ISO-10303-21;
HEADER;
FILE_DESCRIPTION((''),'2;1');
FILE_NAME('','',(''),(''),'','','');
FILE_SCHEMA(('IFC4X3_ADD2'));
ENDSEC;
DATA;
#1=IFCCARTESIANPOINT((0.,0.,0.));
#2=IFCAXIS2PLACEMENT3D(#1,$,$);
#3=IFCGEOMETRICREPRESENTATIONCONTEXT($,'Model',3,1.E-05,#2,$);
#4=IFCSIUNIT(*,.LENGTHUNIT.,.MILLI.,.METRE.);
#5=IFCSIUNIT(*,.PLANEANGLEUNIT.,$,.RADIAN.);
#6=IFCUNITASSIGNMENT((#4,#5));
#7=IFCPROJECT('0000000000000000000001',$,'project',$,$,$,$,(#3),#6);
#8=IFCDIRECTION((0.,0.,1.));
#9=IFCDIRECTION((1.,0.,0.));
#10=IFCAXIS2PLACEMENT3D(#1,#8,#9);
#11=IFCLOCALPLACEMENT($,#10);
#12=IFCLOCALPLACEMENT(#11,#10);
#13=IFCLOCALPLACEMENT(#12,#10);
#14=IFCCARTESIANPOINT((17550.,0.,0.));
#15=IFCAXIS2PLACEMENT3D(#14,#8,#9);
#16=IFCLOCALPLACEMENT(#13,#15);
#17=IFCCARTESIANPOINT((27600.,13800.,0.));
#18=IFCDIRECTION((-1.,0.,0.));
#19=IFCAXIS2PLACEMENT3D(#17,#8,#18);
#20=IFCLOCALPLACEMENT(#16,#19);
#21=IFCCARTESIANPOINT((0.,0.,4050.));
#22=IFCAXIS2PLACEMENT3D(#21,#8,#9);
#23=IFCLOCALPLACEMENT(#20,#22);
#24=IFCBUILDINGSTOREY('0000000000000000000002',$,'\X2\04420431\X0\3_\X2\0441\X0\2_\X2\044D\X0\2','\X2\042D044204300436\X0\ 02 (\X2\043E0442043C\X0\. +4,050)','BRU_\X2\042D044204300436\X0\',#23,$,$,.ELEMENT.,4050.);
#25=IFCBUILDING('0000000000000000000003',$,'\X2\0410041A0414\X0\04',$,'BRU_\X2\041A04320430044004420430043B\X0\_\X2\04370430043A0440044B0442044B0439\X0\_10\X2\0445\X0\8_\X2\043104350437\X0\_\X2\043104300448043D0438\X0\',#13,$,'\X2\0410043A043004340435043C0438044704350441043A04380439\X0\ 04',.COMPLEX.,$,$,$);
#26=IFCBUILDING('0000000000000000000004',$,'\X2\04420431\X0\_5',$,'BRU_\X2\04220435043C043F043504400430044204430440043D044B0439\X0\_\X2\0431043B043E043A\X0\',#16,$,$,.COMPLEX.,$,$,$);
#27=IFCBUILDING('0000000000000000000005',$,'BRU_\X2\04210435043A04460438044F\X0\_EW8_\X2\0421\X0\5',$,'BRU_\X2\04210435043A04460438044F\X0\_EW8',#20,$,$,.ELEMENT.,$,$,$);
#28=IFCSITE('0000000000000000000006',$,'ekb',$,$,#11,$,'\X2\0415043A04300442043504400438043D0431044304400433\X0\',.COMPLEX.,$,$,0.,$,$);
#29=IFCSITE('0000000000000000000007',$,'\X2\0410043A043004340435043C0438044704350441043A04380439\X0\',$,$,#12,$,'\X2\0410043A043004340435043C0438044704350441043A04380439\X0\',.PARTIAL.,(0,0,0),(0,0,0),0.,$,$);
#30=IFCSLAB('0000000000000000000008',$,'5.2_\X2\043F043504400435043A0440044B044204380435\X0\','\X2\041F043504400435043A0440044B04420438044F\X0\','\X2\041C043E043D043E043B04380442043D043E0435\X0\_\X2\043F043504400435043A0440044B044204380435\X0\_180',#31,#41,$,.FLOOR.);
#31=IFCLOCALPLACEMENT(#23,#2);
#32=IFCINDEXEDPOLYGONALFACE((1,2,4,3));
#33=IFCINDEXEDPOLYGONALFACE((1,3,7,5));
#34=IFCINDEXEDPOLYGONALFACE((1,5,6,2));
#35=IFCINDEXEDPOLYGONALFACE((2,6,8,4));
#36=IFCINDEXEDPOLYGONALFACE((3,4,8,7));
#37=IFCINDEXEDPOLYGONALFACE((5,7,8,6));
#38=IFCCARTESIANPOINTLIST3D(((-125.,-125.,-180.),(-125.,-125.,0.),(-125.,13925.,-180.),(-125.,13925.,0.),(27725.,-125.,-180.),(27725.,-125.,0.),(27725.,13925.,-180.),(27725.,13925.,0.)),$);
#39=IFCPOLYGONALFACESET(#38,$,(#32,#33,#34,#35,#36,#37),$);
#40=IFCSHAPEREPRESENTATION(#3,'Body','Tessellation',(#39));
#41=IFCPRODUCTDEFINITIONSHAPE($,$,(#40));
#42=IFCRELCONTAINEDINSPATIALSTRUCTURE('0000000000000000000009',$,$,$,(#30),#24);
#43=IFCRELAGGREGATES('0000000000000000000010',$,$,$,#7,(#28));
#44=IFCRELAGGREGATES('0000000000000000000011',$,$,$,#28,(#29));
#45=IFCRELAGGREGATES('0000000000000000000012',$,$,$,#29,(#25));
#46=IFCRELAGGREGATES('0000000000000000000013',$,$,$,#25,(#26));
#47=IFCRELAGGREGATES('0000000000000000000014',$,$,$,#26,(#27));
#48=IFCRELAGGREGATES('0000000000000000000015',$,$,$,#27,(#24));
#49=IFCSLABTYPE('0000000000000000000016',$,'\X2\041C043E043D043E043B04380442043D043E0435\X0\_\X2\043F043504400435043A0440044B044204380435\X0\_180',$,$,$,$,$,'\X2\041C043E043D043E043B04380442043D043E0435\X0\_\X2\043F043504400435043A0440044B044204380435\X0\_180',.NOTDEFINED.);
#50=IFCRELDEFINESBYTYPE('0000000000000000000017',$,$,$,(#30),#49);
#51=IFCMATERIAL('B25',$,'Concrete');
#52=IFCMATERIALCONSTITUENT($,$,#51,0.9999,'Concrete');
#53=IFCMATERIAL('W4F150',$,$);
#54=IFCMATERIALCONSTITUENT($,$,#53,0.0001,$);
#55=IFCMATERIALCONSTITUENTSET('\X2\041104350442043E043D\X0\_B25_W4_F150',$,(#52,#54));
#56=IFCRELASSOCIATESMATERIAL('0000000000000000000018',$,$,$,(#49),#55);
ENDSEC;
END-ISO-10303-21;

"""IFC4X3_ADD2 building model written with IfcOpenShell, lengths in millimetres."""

from ifc_helpers import new_model, si_unit, frame, origin, origin_with_axes, place, context, project, spatial, polyline, outline, extrude, material, constituent, constituent_set, type_object, element, save


model = new_model("IFC4X3_ADD2")

# Units and contexts
model_context = context("Model", 3, precision=1e-05, world=origin())
ifc_project = project(units=[si_unit("LENGTHUNIT", "METRE", prefix="MILLI"), si_unit("PLANEANGLEUNIT", "RADIAN")], contexts=[model_context])

# Sites, buildings, storey
site_1_placement = place(None, origin_with_axes())
site_1 = spatial("IfcSite", under=ifc_project, at=site_1_placement, Name="ekb", LongName="Екатеринбург", CompositionType="COMPLEX", RefElevation=0.0)
site_2_placement = place(site_1_placement, origin_with_axes())
site_2 = spatial("IfcSite", under=site_1, at=site_2_placement, Name="Академический", LongName="Академический", CompositionType="PARTIAL", RefLatitude=(0, 0, 0), RefLongitude=(0, 0, 0), RefElevation=0.0)
building_1_placement = place(site_2_placement, origin_with_axes())
building_1 = spatial("IfcBuilding", under=site_2, at=building_1_placement, Name="АКД04", ObjectType="BRU_Квартал_закрытый_10х8_без_башни", LongName="Академический 04", CompositionType="COMPLEX")
building_2_placement = place(building_1_placement, frame((17550.0, 0.0, 0.0), z_axis=(0.0, 0.0, 1.0), x_axis=(1.0, 0.0, 0.0)))
building_2 = spatial("IfcBuilding", under=building_1, at=building_2_placement, Name="тб_5", ObjectType="BRU_Температурный_блок", CompositionType="COMPLEX")
building_3_placement = place(building_2_placement, frame((27600.0, 13800.0, 0.0), z_axis=(0.0, 0.0, 1.0), x_axis=(-1.0, 0.0, 0.0)))
building_3 = spatial("IfcBuilding", under=building_2, at=building_3_placement, Name="BRU_Секция_EW8_С5", ObjectType="BRU_Секция_EW8", CompositionType="ELEMENT")
storey_placement = place(building_3_placement, frame((0.0, 0.0, 4050.0), z_axis=(0.0, 0.0, 1.0), x_axis=(1.0, 0.0, 0.0)))
storey = spatial("IfcBuildingStorey", under=building_3, at=storey_placement, Name="тб3_с2_э2", Description="Этаж 02 (отм. +4,050)", ObjectType="BRU_Этаж", CompositionType="ELEMENT", Elevation=4050.0)

# Shared definitions
ifc_material_1 = material(Name="B25", Category="Concrete")
ifc_material_2 = material(Name="W4F150")

# Slab
ifc_constituent_1 = constituent(ifc_material_1, Category="Concrete", fraction=0.9999)
ifc_constituent_2 = constituent(ifc_material_2, fraction=0.0001)
ifc_constituent_set_1 = constituent_set(constituents=[ifc_constituent_1, ifc_constituent_2], Name="Бетон_B25_W4_F150")
slab_type = type_object("IfcSlabType", Name="Монолитное_перекрытие_180", ElementType="Монолитное_перекрытие_180", PredefinedType="NOTDEFINED", material=ifc_constituent_set_1)
slab_placement = place(storey_placement, frame((0.0, 0.0, -180.0), z_axis=(0.0, 0.0, 1.0), x_axis=(1.0, 0.0, 0.0)))
element("IfcSlab", 1, at=slab_placement, inside=storey, type_object=slab_type, Name="5.2_перекрытие", Description="Перекрытия", ObjectType="Монолитное_перекрытие_180", PredefinedType="FLOOR", context=model_context, shape_type="SweptSolid", body=[
    extrude(outline(polyline([(27725.0, 13925.0), (-125.0, 13925.0), (-125.0, -125.0), (27725.0, -125.0), (27725.0, 13925.0)])), origin_with_axes(), (0.0, 0.0, 1.0), 180.0),
])

save(model, "model.ifc")
